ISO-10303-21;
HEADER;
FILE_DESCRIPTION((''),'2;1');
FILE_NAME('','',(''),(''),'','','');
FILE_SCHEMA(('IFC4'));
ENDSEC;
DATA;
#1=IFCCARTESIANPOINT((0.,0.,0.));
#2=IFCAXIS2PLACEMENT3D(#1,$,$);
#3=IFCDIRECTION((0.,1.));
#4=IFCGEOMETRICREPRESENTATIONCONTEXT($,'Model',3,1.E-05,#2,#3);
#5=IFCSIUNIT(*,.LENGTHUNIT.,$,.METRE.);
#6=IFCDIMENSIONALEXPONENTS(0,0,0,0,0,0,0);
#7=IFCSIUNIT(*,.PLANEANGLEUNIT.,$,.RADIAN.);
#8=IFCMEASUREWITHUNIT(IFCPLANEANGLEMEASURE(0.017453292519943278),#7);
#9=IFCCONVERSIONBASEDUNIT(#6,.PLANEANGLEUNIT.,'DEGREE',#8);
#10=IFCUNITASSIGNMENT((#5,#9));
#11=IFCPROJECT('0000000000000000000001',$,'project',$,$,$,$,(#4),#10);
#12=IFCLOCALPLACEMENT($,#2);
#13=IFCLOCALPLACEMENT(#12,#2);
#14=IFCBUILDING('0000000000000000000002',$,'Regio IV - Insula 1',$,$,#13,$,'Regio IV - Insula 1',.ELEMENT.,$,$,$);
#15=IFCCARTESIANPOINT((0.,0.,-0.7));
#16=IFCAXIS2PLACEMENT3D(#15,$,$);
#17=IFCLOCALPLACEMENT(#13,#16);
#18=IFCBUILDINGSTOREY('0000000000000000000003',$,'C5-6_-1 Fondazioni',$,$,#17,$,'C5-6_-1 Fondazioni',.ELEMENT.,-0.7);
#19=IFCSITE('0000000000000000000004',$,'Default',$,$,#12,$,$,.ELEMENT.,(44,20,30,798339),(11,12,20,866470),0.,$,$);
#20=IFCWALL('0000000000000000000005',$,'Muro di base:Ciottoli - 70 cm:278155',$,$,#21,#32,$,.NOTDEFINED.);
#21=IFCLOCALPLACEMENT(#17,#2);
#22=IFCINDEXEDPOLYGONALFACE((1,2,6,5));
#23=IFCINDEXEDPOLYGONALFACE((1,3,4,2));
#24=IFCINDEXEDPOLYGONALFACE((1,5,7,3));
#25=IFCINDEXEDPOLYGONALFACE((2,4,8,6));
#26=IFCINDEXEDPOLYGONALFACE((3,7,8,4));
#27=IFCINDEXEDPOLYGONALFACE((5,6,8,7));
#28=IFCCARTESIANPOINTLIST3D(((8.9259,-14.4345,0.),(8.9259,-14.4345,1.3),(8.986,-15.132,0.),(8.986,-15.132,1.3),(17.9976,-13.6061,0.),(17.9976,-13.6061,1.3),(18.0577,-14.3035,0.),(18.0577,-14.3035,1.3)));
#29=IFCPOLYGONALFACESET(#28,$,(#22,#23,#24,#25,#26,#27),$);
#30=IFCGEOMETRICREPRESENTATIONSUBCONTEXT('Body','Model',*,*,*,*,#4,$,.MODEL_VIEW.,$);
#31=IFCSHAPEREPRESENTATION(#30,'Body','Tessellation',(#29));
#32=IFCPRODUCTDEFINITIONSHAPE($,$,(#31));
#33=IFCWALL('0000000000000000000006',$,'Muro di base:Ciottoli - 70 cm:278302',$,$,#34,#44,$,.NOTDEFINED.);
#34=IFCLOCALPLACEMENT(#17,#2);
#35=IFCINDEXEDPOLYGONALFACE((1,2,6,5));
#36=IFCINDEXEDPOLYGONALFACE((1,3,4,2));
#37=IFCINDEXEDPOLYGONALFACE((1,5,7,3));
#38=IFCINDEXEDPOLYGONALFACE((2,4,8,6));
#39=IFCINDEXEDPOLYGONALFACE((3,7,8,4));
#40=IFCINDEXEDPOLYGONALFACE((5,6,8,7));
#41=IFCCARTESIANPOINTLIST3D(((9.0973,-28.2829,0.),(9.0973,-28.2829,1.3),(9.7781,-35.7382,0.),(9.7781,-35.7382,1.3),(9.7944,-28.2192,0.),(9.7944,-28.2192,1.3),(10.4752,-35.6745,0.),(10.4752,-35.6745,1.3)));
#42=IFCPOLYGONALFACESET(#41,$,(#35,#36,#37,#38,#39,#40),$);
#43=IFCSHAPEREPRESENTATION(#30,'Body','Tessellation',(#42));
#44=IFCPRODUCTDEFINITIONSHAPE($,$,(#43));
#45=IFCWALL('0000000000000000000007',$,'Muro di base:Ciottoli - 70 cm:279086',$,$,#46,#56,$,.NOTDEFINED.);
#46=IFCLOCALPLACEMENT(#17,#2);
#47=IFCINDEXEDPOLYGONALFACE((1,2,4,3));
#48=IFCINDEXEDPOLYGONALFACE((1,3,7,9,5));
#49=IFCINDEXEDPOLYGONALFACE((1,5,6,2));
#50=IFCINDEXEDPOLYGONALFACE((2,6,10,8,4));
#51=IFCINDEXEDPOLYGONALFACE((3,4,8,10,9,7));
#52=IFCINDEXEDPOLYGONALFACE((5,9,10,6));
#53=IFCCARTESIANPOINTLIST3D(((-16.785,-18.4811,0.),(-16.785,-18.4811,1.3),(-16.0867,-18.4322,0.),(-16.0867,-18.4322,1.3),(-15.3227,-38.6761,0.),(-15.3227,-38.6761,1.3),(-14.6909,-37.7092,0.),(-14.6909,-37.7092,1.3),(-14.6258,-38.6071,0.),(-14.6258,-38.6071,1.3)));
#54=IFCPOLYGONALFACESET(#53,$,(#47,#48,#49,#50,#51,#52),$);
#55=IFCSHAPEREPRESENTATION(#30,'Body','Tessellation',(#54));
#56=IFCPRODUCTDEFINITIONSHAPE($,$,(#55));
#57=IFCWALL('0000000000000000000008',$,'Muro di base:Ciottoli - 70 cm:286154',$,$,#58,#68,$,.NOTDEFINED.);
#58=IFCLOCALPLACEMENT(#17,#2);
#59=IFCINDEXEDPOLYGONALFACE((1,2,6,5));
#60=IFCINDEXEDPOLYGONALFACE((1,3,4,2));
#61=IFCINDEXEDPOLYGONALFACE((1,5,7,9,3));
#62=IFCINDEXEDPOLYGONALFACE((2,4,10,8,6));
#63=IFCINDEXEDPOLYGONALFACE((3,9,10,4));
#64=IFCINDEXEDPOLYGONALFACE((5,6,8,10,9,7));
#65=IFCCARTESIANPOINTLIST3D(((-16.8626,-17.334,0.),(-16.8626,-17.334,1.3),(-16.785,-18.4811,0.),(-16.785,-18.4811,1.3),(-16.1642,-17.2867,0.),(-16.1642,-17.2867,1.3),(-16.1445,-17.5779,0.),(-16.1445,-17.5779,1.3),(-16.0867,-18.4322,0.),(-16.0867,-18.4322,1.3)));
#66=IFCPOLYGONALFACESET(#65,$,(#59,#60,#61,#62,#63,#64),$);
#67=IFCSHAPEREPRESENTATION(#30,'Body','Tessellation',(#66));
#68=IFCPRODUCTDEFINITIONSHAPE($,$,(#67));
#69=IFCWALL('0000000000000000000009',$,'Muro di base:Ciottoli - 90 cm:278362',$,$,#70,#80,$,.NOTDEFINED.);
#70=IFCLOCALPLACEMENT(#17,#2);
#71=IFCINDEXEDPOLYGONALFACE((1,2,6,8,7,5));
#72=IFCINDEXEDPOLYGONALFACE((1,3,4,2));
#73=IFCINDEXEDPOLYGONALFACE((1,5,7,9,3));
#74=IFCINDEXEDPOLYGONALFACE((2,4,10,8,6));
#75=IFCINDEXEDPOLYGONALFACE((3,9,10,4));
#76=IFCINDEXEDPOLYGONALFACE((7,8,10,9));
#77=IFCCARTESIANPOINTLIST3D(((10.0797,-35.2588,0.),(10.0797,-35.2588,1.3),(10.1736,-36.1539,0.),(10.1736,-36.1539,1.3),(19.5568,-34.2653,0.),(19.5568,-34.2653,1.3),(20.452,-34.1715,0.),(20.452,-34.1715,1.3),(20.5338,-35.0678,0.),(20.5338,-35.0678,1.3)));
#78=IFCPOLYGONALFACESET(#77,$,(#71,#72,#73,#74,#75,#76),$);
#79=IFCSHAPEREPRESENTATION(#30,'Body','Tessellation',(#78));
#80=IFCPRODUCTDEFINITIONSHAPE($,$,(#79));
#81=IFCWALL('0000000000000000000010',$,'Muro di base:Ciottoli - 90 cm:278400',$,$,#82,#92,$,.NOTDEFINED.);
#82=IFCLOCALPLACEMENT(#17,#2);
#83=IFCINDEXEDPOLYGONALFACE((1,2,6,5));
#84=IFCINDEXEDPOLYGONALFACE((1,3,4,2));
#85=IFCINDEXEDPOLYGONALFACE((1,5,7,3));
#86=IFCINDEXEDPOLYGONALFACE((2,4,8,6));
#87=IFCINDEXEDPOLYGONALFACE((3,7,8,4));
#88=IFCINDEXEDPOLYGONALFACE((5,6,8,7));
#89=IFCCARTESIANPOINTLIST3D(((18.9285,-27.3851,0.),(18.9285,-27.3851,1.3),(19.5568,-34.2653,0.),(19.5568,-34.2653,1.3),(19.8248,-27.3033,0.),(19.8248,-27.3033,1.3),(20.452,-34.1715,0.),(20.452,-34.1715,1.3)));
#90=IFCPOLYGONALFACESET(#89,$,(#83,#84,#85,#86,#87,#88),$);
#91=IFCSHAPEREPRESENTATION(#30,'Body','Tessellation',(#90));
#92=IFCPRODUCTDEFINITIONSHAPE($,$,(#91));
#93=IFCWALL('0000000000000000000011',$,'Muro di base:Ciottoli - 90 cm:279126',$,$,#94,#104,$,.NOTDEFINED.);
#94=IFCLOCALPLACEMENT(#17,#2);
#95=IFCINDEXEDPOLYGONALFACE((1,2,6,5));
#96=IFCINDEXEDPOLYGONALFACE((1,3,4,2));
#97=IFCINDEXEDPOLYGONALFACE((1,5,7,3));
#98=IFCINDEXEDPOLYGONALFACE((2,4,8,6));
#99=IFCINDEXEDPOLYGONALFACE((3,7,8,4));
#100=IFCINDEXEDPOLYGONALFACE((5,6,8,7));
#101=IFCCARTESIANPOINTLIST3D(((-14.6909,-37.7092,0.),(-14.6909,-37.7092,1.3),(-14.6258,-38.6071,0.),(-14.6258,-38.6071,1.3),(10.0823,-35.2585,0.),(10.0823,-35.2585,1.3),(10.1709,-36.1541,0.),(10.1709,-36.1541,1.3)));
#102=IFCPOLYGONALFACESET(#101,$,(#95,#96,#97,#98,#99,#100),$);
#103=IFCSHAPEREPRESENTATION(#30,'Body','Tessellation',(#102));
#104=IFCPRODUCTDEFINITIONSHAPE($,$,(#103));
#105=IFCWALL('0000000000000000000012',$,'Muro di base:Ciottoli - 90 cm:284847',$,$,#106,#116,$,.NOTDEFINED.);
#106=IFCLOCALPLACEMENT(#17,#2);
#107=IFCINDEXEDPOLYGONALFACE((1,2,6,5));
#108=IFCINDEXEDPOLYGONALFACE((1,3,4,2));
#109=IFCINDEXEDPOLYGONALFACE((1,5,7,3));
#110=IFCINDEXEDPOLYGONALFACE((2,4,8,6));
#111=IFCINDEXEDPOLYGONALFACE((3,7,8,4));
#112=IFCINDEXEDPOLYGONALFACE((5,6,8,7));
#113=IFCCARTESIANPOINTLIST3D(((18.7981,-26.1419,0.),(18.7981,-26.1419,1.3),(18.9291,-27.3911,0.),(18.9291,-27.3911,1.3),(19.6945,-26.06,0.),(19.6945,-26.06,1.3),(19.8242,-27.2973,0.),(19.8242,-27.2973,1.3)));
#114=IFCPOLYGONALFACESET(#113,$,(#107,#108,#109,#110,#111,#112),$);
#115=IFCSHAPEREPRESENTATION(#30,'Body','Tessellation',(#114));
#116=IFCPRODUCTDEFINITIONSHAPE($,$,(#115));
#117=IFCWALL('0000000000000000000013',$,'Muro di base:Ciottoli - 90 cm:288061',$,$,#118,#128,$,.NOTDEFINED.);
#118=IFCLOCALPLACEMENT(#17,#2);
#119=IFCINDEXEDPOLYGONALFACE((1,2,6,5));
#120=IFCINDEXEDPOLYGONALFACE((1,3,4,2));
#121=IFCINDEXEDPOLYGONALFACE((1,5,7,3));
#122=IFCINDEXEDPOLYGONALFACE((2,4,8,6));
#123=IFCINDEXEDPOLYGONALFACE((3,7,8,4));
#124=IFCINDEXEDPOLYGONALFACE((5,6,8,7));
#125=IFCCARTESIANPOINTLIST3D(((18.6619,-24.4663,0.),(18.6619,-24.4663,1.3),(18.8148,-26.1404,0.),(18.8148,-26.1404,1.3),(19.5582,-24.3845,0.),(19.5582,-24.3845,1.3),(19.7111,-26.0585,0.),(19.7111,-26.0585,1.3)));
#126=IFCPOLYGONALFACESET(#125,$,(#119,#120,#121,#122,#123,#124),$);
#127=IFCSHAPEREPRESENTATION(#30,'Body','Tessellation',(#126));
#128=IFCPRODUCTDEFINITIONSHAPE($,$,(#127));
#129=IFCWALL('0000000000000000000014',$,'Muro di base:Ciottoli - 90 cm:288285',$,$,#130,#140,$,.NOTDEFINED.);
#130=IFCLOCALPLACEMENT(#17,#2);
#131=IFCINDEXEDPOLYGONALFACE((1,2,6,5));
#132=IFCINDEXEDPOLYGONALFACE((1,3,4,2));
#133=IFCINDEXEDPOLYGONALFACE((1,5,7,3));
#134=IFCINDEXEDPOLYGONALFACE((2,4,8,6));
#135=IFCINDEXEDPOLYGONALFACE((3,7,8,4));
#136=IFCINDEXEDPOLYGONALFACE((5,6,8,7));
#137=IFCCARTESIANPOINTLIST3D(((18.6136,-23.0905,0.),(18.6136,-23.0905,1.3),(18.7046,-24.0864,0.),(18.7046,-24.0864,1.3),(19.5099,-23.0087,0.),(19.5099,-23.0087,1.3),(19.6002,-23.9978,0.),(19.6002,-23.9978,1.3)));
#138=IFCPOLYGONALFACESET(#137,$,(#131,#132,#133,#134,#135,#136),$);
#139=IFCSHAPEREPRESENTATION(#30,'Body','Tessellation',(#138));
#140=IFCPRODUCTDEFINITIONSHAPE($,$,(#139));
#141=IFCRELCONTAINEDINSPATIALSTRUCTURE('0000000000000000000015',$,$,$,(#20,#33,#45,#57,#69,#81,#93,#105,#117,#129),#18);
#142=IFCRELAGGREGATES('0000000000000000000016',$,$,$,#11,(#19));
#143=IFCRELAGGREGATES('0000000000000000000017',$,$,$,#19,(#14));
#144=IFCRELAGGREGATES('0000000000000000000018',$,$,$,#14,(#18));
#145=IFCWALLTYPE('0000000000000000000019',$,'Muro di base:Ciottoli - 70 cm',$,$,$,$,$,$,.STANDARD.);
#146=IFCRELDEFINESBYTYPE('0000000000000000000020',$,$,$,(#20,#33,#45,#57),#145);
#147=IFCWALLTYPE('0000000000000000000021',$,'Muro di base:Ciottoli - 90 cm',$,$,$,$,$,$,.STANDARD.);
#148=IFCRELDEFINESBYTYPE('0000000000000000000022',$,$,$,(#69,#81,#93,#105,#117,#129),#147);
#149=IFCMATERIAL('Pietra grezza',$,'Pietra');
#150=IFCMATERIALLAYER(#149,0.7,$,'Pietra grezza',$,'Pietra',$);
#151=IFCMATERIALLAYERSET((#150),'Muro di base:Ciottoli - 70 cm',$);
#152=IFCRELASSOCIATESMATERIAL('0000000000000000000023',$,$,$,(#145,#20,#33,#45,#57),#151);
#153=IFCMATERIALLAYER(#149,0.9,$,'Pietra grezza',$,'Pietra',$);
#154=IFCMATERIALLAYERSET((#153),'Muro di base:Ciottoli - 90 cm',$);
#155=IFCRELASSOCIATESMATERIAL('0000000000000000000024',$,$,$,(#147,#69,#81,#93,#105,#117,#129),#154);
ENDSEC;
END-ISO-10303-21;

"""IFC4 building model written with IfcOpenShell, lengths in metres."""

from ifc_helpers import new_model, entity, si_unit, converted_unit, direction, frame, frame_2d, origin, place, context, subcontext, project, spatial, polyline, rectangle, outline, extrude, material, layer, layer_set, layer_usage, type_object, element, save


model = new_model("IFC4")

# Units and contexts
model_context = context("Model", 3, precision=1e-05, world=origin(), true_north=direction((0.0, 1.0)))
body_context = subcontext(model_context, "Body", "Model", "MODEL_VIEW")
ifc_project = project(units=[si_unit("LENGTHUNIT", "METRE"), converted_unit("PLANEANGLEUNIT", "DEGREE", entity("IfcPlaneAngleMeasure", 0.017453292519943278), si_unit("PLANEANGLEUNIT", "RADIAN"), dimensions=[0, 0, 0, 0, 0, 0, 0])], contexts=[model_context])

# Site, building, storey
site_placement = place(None, origin())
site = spatial("IfcSite", under=ifc_project, at=site_placement, Name="Default", CompositionType="ELEMENT", RefLatitude=(44, 20, 30, 798339), RefLongitude=(11, 12, 20, 866470), RefElevation=0.0)
building_placement = place(site_placement, origin())
building = spatial("IfcBuilding", under=site, at=building_placement, Name="Regio IV - Insula 1", LongName="Regio IV - Insula 1", CompositionType="ELEMENT")
storey_placement = place(building_placement, frame((0.0, 0.0, -0.7)))
storey = spatial("IfcBuildingStorey", under=building, at=storey_placement, Name="C5-6_-1 Fondazioni", LongName="C5-6_-1 Fondazioni", CompositionType="ELEMENT", Elevation=-0.7)

# Walls
ifc_material = material(Name="Pietra grezza", Category="Pietra")
ifc_layer_1 = layer(ifc_material, 0.7, Name="Pietra grezza", Category="Pietra")
ifc_layer_set_1 = layer_set([ifc_layer_1], Name="Muro di base:Ciottoli - 70 cm")
wall_type_1 = type_object("IfcWallType", Name="Muro di base:Ciottoli - 70 cm", PredefinedType="STANDARD", material=ifc_layer_set_1)
ifc_layer_usage_1 = layer_usage(ifc_layer_set_1, "AXIS2", "NEGATIVE", 0.35)
wall_1_placement = place(storey_placement, frame((18.0294, -13.9547, 0.0), z_axis=(0.0, 0.0, 1.0), x_axis=(-0.995856, -0.090941, 0.0)))
element("IfcWall", 1, at=wall_1_placement, inside=storey, type_object=wall_type_1, material=ifc_layer_usage_1, Name="Muro di base:Ciottoli - 70 cm:278155", PredefinedType="NOTDEFINED", context=body_context, shape_type="SweptSolid", body=[
    extrude(outline(polyline([(9.1094, -0.35), (9.1131, 0.35), (0.0036, 0.35), (0.0, -0.35), (9.1094, -0.35)])), origin(), (0.0, 0.0, 1.0), 1.3),
])
ifc_layer_usage_2 = layer_usage(ifc_layer_set_1, "AXIS2", "NEGATIVE", 0.35)
wall_2_placement = place(storey_placement, frame((9.4458, -28.251, 0.0), z_axis=(0.0, 0.0, 1.0), x_axis=(0.090941, -0.995856, 0.0)))
element("IfcWall", 2, at=wall_2_placement, inside=storey, type_object=wall_type_1, material=ifc_layer_usage_2, Name="Muro di base:Ciottoli - 70 cm:278302", PredefinedType="NOTDEFINED", context=body_context, shape_type="SweptSolid", body=[
    extrude(rectangle(XDim=7.4863, YDim=0.7, at=frame_2d((3.7432, 0.0), x_axis=(-1.0, 0.0))), origin(), (0.0, 0.0, 1.0), 1.3),
])

# Walls
ifc_layer_usage_3 = layer_usage(ifc_layer_set_1, "AXIS2", "NEGATIVE", 0.35)
wall_3_placement = place(storey_placement, frame((-16.4359, -18.4558, 0.0), z_axis=(0.0, 0.0, 1.0), x_axis=(0.07222, -0.997389, 0.0)))
element("IfcWall", 3, at=wall_3_placement, inside=storey, type_object=wall_type_1, material=ifc_layer_usage_3, Name="Muro di base:Ciottoli - 70 cm:279086", PredefinedType="NOTDEFINED", context=body_context, shape_type="SweptSolid", body=[
    extrude(outline(polyline([(20.2478, -0.35), (20.2294, 0.35), (19.3291, 0.35), (0.0016, 0.35), (0.0, -0.35), (20.2478, -0.35)])), origin(), (0.0, 0.0, 1.0), 1.3),
])
ifc_layer_usage_4 = layer_usage(ifc_layer_set_1, "AXIS2", "NEGATIVE", 0.35)
wall_4_placement = place(storey_placement, frame((-16.4358, -18.4575, 0.0), z_axis=(0.0, 0.0, 1.0), x_axis=(-0.067526, 0.997718, 0.0)))
element("IfcWall", 4, at=wall_4_placement, inside=storey, type_object=wall_type_1, material=ifc_layer_usage_4, Name="Muro di base:Ciottoli - 70 cm:286154", PredefinedType="NOTDEFINED", context=body_context, shape_type="SweptSolid", body=[
    extrude(outline(polyline([(1.1498, -0.35), (1.1498, 0.35), (0.0, 0.35), (0.0016, -0.35), (0.8579, -0.35), (1.1498, -0.35)])), origin(), (0.0, 0.0, 1.0), 1.3),
])
ifc_layer_2 = layer(ifc_material, 0.9, Name="Pietra grezza", Category="Pietra")
ifc_layer_set_2 = layer_set([ifc_layer_2], Name="Muro di base:Ciottoli - 90 cm")
ifc_layer_usage_5 = layer_usage(ifc_layer_set_2, "AXIS2", "NEGATIVE", 0.45)
wall_type_2 = type_object("IfcWallType", Name="Muro di base:Ciottoli - 90 cm", PredefinedType="STANDARD", material=ifc_layer_set_2)
wall_5_placement = place(storey_placement, frame((10.1266, -35.7063, 0.0), z_axis=(0.0, 0.0, 1.0), x_axis=(0.99455, 0.104256, 0.0)))
element("IfcWall", 5, at=wall_5_placement, inside=storey, type_object=wall_type_2, material=ifc_layer_usage_5, Name="Muro di base:Ciottoli - 90 cm:278362", PredefinedType="NOTDEFINED", context=body_context, shape_type="SweptSolid", body=[
    extrude(outline(polyline([(10.417, -0.45), (10.4291, 0.45), (9.529, 0.45), (0.0, 0.45), (0.0, -0.45), (10.417, -0.45)])), origin(), (0.0, 0.0, 1.0), 1.3),
])
ifc_layer_usage_6 = layer_usage(ifc_layer_set_2, "AXIS2", "NEGATIVE", 0.45)
wall_6_placement = place(storey_placement, frame((20.0049, -34.2244, 0.0), z_axis=(0.0, 0.0, 1.0), x_axis=(-0.090941, 0.995856, 0.0)))
element("IfcWall", 6, at=wall_6_placement, inside=storey, type_object=wall_type_2, material=ifc_layer_usage_6, Name="Muro di base:Ciottoli - 90 cm:278400", PredefinedType="NOTDEFINED", context=body_context, shape_type="SweptSolid", body=[
    extrude(outline(polyline([(6.9089, -0.45), (6.9089, 0.45), (0.0, 0.45), (0.012, -0.45), (6.9089, -0.45)])), origin(), (0.0, 0.0, 1.0), 1.3),
])
ifc_layer_usage_7 = layer_usage(ifc_layer_set_2, "AXIS2", "NEGATIVE", 0.45)
wall_7_placement = place(storey_placement, frame((-14.6701, -38.1593, 0.0), z_axis=(0.0, 0.0, 1.0), x_axis=(0.995143, 0.098443, 0.0)))
element("IfcWall", 7, at=wall_7_placement, inside=storey, type_object=wall_type_2, material=ifc_layer_usage_7, Name="Muro di base:Ciottoli - 90 cm:279126", PredefinedType="NOTDEFINED", context=body_context, shape_type="SweptSolid", body=[
    extrude(outline(polyline([(24.9178, -0.45), (24.9178, 0.45), (0.0237, 0.45), (0.0, -0.45), (24.9178, -0.45)])), origin(), (0.0, 0.0, 1.0), 1.3),
])
ifc_layer_usage_8 = layer_usage(ifc_layer_set_2, "AXIS2", "NEGATIVE", 0.45)
wall_8_placement = place(storey_placement, frame((19.3766, -27.3442, 0.0), z_axis=(0.0, 0.0, 1.0), x_axis=(-0.104256, 0.99455, 0.0)))
element("IfcWall", 8, at=wall_8_placement, inside=storey, type_object=wall_type_2, material=ifc_layer_usage_8, Name="Muro di base:Ciottoli - 90 cm:284847", PredefinedType="NOTDEFINED", context=body_context, shape_type="SweptSolid", body=[
    extrude(outline(polyline([(1.244, -0.45), (1.2561, 0.45), (0.0, 0.45), (0.0, -0.45), (1.244, -0.45)])), origin(), (0.0, 0.0, 1.0), 1.3),
])
ifc_layer_usage_9 = layer_usage(ifc_layer_set_2, "AXIS2", "NEGATIVE", 0.45)
wall_9_placement = place(storey_placement, frame((19.2629, -26.0994, 0.0), z_axis=(0.0, 0.0, 1.0), x_axis=(-0.090941, 0.995856, 0.0)))
element("IfcWall", 9, at=wall_9_placement, inside=storey, type_object=wall_type_2, material=ifc_layer_usage_9, Name="Muro di base:Ciottoli - 90 cm:288061", PredefinedType="NOTDEFINED", context=body_context, shape_type="SweptSolid", body=[
    extrude(rectangle(XDim=1.681, YDim=0.9, at=frame_2d((0.8405, 0.0), x_axis=(-1.0, 0.0))), origin(), (0.0, 0.0, 1.0), 1.3),
])
ifc_layer_usage_10 = layer_usage(ifc_layer_set_2, "AXIS2", "NEGATIVE", 0.45)
wall_10_placement = place(storey_placement, frame((19.0618, -23.0496, 0.0), z_axis=(0.0, 0.0, 1.0), x_axis=(0.090941, -0.995856, 0.0)))
element("IfcWall", 10, at=wall_10_placement, inside=storey, type_object=wall_type_2, material=ifc_layer_usage_10, Name="Muro di base:Ciottoli - 90 cm:288285", PredefinedType="NOTDEFINED", context=body_context, shape_type="SweptSolid", body=[
    extrude(outline(polyline([(1.0, -0.45), (0.9932, 0.45), (0.0, 0.45), (0.0, -0.45), (1.0, -0.45)])), origin(), (0.0, 0.0, 1.0), 1.3),
])

save(model, "model.ifc")
